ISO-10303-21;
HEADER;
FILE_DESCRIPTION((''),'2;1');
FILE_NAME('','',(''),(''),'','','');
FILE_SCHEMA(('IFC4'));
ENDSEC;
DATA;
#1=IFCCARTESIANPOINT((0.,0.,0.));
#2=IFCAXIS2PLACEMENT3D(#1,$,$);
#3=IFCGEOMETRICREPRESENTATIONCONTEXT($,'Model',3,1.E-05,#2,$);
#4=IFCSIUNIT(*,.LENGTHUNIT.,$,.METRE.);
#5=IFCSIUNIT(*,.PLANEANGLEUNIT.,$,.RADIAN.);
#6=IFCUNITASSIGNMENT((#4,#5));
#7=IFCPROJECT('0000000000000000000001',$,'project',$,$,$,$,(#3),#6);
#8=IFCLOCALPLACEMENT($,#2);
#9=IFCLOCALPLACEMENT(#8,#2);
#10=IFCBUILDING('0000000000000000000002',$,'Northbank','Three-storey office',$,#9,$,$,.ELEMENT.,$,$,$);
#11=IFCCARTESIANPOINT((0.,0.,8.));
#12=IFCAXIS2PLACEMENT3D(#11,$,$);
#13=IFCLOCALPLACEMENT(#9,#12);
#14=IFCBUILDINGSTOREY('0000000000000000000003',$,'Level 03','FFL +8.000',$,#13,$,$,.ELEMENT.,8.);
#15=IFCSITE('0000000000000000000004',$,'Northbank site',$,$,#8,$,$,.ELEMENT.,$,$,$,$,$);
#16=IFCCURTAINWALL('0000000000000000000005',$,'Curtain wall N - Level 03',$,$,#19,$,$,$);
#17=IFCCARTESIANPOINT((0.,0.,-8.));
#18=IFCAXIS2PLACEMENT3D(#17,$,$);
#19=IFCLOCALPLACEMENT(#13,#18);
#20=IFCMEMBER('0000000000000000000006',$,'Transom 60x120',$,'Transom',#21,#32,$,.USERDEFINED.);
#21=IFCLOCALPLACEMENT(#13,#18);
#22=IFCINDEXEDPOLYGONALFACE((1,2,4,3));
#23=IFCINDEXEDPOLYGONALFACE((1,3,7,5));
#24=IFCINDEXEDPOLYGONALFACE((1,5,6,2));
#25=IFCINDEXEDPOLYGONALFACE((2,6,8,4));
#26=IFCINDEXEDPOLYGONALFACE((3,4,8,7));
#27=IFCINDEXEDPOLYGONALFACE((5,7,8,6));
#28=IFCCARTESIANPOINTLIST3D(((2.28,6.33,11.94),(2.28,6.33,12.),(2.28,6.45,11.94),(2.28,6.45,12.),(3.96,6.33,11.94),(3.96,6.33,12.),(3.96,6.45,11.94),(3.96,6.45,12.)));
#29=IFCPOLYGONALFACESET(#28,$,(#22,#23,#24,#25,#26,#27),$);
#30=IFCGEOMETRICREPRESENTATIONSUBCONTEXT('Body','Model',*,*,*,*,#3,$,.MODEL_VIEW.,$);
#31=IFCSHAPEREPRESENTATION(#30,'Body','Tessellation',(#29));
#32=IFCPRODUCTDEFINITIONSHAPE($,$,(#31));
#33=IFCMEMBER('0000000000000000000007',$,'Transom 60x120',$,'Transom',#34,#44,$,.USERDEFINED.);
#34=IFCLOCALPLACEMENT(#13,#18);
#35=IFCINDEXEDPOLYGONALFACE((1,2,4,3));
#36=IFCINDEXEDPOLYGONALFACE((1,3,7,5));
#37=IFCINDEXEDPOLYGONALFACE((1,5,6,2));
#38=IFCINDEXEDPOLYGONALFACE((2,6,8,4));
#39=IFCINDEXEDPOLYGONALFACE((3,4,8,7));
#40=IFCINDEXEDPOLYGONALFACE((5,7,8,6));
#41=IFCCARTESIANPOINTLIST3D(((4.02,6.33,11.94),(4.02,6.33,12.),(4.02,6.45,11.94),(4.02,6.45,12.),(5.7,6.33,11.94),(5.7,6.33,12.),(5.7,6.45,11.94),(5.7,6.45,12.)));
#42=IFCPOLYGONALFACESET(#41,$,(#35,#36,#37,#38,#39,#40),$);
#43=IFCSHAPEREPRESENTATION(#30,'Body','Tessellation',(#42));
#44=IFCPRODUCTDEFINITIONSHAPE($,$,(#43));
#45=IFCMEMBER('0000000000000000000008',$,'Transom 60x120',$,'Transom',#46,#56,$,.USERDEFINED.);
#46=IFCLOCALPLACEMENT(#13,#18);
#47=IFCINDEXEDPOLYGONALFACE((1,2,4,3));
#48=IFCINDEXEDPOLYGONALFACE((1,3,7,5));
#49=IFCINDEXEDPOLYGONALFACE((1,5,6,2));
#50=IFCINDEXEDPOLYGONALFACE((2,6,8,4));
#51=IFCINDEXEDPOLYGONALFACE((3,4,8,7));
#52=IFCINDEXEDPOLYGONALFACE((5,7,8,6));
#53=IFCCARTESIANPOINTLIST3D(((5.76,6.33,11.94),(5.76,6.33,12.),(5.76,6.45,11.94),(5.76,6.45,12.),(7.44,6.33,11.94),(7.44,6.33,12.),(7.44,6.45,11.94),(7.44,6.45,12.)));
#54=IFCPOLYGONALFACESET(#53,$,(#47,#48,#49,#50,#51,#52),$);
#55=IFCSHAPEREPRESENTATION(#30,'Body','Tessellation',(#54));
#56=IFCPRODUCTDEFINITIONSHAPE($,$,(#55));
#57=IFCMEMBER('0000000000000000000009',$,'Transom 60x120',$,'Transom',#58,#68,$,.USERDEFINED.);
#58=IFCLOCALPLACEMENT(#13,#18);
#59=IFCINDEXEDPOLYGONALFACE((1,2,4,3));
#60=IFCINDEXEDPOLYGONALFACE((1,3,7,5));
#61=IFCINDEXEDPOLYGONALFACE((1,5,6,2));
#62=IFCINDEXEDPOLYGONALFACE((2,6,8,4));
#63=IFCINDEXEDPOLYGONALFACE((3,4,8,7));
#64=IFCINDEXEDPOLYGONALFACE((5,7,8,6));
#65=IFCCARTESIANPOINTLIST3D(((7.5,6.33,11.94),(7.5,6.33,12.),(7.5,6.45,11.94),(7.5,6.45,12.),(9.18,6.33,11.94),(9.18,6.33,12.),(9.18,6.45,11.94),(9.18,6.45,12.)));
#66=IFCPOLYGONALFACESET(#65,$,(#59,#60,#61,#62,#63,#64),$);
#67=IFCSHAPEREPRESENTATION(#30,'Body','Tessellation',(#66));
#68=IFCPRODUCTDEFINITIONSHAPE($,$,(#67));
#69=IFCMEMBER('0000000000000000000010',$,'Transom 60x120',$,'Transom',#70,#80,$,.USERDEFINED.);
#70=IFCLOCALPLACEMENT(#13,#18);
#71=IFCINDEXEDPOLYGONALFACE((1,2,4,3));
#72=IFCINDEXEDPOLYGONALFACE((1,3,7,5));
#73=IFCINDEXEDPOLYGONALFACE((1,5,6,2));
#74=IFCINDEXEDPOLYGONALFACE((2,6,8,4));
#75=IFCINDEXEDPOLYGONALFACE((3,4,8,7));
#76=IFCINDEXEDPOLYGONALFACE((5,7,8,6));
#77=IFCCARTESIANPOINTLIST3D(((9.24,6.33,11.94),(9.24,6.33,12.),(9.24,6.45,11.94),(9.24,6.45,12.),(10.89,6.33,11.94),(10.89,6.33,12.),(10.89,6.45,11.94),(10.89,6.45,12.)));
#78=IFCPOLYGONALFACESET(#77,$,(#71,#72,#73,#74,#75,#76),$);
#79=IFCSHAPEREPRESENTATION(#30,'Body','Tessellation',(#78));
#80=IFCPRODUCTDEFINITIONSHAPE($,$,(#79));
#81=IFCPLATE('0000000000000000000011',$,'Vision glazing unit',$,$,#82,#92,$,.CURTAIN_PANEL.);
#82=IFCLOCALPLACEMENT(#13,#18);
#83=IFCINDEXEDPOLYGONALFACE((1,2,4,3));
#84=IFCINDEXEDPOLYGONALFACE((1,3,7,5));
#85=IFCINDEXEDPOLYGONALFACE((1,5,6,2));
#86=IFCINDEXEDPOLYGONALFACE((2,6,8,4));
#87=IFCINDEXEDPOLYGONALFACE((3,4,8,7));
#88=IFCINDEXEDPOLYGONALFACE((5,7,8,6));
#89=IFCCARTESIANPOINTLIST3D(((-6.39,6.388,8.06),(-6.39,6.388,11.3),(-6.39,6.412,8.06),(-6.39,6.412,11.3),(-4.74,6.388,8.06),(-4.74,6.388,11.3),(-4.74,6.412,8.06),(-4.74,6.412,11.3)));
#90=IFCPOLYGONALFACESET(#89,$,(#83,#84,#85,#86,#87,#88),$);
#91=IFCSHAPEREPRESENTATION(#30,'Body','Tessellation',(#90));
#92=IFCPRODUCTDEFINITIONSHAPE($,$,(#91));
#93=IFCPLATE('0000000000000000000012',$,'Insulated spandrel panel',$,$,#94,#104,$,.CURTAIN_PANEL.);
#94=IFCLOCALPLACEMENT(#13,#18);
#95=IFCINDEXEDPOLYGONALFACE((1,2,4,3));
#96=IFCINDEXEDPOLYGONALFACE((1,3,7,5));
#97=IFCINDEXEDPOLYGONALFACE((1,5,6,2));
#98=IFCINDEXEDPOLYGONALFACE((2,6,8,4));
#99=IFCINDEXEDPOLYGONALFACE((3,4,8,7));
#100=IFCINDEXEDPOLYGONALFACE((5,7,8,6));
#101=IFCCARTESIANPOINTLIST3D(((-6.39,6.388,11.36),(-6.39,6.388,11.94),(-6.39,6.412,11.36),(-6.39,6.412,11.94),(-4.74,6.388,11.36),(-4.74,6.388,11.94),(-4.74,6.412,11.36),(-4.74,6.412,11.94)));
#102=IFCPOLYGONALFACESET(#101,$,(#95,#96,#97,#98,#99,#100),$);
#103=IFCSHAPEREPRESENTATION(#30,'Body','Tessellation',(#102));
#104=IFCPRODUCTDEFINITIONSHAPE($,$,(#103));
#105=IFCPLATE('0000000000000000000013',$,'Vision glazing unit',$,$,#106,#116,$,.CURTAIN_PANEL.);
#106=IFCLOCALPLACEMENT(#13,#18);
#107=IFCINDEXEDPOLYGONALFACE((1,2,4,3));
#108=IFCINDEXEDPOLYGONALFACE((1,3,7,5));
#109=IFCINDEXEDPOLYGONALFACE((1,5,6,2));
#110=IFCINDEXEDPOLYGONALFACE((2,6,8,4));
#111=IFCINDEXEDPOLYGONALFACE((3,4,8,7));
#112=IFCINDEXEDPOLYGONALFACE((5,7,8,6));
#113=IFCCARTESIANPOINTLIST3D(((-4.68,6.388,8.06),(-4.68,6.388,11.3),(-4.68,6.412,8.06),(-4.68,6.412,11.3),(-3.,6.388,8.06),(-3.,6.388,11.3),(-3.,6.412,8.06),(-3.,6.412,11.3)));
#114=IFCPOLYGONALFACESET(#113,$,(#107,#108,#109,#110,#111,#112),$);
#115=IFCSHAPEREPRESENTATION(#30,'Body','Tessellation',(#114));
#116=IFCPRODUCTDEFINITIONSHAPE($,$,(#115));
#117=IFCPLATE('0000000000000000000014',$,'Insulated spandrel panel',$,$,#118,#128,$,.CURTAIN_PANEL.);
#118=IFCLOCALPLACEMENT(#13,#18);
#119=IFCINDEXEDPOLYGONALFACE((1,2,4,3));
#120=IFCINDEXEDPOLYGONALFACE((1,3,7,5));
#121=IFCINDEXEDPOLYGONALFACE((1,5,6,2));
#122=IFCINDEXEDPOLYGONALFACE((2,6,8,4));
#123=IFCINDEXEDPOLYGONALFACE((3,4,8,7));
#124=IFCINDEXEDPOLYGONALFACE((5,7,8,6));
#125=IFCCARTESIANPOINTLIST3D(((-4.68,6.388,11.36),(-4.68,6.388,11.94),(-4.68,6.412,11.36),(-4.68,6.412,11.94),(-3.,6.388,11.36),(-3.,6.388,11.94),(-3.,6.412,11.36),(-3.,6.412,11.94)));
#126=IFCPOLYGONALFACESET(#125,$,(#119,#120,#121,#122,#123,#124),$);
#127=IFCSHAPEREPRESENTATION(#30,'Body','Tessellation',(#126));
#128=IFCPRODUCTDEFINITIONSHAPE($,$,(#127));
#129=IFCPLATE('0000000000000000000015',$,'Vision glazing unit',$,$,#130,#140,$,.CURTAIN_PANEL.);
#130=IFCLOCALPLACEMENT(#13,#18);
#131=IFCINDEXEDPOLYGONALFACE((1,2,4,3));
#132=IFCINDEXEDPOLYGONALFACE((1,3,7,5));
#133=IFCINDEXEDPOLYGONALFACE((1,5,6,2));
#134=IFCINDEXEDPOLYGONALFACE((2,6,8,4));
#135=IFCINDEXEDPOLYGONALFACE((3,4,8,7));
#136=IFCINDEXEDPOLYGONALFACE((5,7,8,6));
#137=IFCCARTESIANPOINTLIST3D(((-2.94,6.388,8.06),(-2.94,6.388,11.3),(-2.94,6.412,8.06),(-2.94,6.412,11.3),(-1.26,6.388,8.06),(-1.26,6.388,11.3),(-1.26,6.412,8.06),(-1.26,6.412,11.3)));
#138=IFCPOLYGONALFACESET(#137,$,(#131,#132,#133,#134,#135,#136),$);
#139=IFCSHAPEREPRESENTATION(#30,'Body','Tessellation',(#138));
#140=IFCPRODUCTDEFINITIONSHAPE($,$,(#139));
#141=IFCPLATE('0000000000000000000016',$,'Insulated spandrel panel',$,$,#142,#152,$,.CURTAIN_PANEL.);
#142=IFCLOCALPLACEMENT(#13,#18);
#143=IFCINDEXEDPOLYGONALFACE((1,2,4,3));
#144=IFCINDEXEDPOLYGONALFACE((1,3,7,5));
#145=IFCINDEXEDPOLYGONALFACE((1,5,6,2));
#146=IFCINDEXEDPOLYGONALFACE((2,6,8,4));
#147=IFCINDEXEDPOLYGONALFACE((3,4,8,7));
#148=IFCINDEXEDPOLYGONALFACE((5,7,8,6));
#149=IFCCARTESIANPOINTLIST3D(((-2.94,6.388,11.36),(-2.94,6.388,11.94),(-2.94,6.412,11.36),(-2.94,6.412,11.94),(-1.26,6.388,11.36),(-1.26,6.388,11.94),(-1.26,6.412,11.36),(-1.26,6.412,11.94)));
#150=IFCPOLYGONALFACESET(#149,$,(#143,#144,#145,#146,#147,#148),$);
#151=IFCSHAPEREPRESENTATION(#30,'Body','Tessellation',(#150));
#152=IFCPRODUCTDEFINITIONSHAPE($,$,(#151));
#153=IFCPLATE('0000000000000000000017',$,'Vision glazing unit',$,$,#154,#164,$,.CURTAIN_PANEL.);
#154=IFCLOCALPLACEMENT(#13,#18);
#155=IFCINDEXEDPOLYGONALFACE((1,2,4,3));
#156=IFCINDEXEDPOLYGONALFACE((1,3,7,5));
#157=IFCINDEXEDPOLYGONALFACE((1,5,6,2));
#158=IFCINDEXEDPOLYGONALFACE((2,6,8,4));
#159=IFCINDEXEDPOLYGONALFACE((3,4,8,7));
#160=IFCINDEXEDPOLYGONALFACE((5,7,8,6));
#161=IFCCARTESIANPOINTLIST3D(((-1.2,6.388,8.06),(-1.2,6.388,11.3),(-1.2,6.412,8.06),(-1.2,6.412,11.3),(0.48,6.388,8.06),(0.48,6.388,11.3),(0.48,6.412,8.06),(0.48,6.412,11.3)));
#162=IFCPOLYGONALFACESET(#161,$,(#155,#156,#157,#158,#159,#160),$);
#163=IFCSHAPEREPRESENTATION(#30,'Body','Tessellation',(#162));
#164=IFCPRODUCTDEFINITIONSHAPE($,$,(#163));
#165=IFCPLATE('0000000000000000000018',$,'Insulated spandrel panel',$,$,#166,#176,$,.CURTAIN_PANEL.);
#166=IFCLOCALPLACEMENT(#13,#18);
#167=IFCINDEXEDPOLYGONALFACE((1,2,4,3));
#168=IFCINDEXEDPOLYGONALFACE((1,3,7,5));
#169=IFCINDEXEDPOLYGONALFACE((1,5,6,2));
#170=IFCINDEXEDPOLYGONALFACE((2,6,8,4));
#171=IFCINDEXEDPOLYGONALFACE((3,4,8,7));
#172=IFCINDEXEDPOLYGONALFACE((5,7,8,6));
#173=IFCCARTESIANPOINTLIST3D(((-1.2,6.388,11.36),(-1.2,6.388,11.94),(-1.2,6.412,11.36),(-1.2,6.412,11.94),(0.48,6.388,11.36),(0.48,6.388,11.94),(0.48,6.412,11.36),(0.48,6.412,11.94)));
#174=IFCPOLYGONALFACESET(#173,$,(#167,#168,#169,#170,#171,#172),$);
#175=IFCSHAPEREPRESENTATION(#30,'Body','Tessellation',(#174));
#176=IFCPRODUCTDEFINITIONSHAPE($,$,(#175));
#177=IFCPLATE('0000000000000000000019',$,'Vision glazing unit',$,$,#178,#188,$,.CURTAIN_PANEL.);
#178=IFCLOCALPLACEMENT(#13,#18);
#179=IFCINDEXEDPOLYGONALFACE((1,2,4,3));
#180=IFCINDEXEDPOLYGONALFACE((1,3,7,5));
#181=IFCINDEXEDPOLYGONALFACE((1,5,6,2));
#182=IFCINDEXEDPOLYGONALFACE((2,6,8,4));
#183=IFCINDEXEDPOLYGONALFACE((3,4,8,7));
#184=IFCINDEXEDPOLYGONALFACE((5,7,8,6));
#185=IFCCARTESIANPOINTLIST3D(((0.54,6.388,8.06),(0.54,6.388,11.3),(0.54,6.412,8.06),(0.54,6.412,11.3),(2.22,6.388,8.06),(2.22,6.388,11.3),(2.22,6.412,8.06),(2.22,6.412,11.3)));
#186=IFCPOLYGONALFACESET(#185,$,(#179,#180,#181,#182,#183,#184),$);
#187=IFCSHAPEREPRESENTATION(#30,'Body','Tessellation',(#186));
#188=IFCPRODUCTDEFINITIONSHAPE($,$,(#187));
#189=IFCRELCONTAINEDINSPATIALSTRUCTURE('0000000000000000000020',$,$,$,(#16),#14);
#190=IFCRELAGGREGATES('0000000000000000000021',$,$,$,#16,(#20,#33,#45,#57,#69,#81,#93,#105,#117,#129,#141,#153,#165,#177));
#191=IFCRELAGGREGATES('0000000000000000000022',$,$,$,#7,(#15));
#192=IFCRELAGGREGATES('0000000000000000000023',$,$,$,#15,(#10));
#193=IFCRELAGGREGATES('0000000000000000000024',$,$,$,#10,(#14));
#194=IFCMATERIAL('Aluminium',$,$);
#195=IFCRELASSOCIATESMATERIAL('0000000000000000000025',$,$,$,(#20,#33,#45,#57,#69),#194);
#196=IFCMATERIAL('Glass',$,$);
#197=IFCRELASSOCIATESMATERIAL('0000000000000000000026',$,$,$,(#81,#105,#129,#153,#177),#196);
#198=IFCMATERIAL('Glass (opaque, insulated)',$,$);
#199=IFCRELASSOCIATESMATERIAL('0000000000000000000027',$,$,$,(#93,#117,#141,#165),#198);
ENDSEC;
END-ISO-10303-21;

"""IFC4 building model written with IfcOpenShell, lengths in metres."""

from ifc_helpers import new_model, si_unit, frame, origin, place, context, subcontext, project, spatial, rectangle, extrude, material, element, aggregate, save


model = new_model("IFC4")

# Units and contexts
model_context = context("Model", 3, precision=1e-05, world=origin())
body_context = subcontext(model_context, "Body", "Model", "MODEL_VIEW")
ifc_project = project(units=[si_unit("LENGTHUNIT", "METRE"), si_unit("PLANEANGLEUNIT", "RADIAN")], contexts=[model_context])

# Site, building, storey
site_placement = place(None, origin())
site = spatial("IfcSite", under=ifc_project, at=site_placement, Name="Northbank site", CompositionType="ELEMENT")
building_placement = place(site_placement, origin())
building = spatial("IfcBuilding", under=site, at=building_placement, Name="Northbank", Description="Three-storey office", CompositionType="ELEMENT")
storey_placement = place(building_placement, frame((0.0, 0.0, 8.0)))
storey = spatial("IfcBuildingStorey", under=building, at=storey_placement, Name="Level 03", Description="FFL +8.000", CompositionType="ELEMENT", Elevation=8.0)

# Curtain wall, members, plates
curtain_wall_placement = place(storey_placement, frame((0.0, 0.0, -8.0)))
curtain_wall = element("IfcCurtainWall", 1, at=curtain_wall_placement, inside=storey, Name="Curtain wall N - Level 03")
ifc_material_1 = material(Name="Aluminium")
member_1_placement = place(storey_placement, frame((0.0, 0.0, -8.0)))
member_1 = element("IfcMember", 2, at=member_1_placement, material=ifc_material_1, Name="Transom 60x120", ObjectType="Transom", PredefinedType="USERDEFINED", context=body_context, shape_type="SweptSolid", body=[
    extrude(rectangle(XDim=1.68, YDim=0.12), frame((3.12, 6.39, 11.94)), (0.0, 0.0, 1.0), 0.06),
])
member_2_placement = place(storey_placement, frame((0.0, 0.0, -8.0)))
member_2 = element("IfcMember", 3, at=member_2_placement, material=ifc_material_1, Name="Transom 60x120", ObjectType="Transom", PredefinedType="USERDEFINED", context=body_context, shape_type="SweptSolid", body=[
    extrude(rectangle(XDim=1.68, YDim=0.12), frame((4.86, 6.39, 11.94)), (0.0, 0.0, 1.0), 0.06),
])
member_3_placement = place(storey_placement, frame((0.0, 0.0, -8.0)))
member_3 = element("IfcMember", 4, at=member_3_placement, material=ifc_material_1, Name="Transom 60x120", ObjectType="Transom", PredefinedType="USERDEFINED", context=body_context, shape_type="SweptSolid", body=[
    extrude(rectangle(XDim=1.68, YDim=0.12), frame((6.6, 6.39, 11.94)), (0.0, 0.0, 1.0), 0.06),
])
member_4_placement = place(storey_placement, frame((0.0, 0.0, -8.0)))
member_4 = element("IfcMember", 5, at=member_4_placement, material=ifc_material_1, Name="Transom 60x120", ObjectType="Transom", PredefinedType="USERDEFINED", context=body_context, shape_type="SweptSolid", body=[
    extrude(rectangle(XDim=1.68, YDim=0.12), frame((8.34, 6.39, 11.94)), (0.0, 0.0, 1.0), 0.06),
])
member_5_placement = place(storey_placement, frame((0.0, 0.0, -8.0)))
member_5 = element("IfcMember", 6, at=member_5_placement, material=ifc_material_1, Name="Transom 60x120", ObjectType="Transom", PredefinedType="USERDEFINED", context=body_context, shape_type="SweptSolid", body=[
    extrude(rectangle(XDim=1.65, YDim=0.12), frame((10.065, 6.39, 11.94)), (0.0, 0.0, 1.0), 0.06),
])
ifc_material_2 = material(Name="Glass")
plate_1_placement = place(storey_placement, frame((0.0, 0.0, -8.0)))
plate_1 = element("IfcPlate", 7, at=plate_1_placement, material=ifc_material_2, Name="Vision glazing unit", PredefinedType="CURTAIN_PANEL", context=body_context, shape_type="SweptSolid", body=[
    extrude(rectangle(XDim=1.65, YDim=0.024), frame((-5.565, 6.4, 8.06)), (0.0, 0.0, 1.0), 3.24),
])
ifc_material_3 = material(Name="Glass (opaque, insulated)")
plate_2_placement = place(storey_placement, frame((0.0, 0.0, -8.0)))
plate_2 = element("IfcPlate", 8, at=plate_2_placement, material=ifc_material_3, Name="Insulated spandrel panel", PredefinedType="CURTAIN_PANEL", context=body_context, shape_type="SweptSolid", body=[
    extrude(rectangle(XDim=1.65, YDim=0.024), frame((-5.565, 6.4, 11.36)), (0.0, 0.0, 1.0), 0.58),
])
plate_3_placement = place(storey_placement, frame((0.0, 0.0, -8.0)))
plate_3 = element("IfcPlate", 9, at=plate_3_placement, material=ifc_material_2, Name="Vision glazing unit", PredefinedType="CURTAIN_PANEL", context=body_context, shape_type="SweptSolid", body=[
    extrude(rectangle(XDim=1.68, YDim=0.024), frame((-3.84, 6.4, 8.06)), (0.0, 0.0, 1.0), 3.24),
])
plate_4_placement = place(storey_placement, frame((0.0, 0.0, -8.0)))
plate_4 = element("IfcPlate", 10, at=plate_4_placement, material=ifc_material_3, Name="Insulated spandrel panel", PredefinedType="CURTAIN_PANEL", context=body_context, shape_type="SweptSolid", body=[
    extrude(rectangle(XDim=1.68, YDim=0.024), frame((-3.84, 6.4, 11.36)), (0.0, 0.0, 1.0), 0.58),
])
plate_5_placement = place(storey_placement, frame((0.0, 0.0, -8.0)))
plate_5 = element("IfcPlate", 11, at=plate_5_placement, material=ifc_material_2, Name="Vision glazing unit", PredefinedType="CURTAIN_PANEL", context=body_context, shape_type="SweptSolid", body=[
    extrude(rectangle(XDim=1.68, YDim=0.024), frame((-2.1, 6.4, 8.06)), (0.0, 0.0, 1.0), 3.24),
])
plate_6_placement = place(storey_placement, frame((0.0, 0.0, -8.0)))
plate_6 = element("IfcPlate", 12, at=plate_6_placement, material=ifc_material_3, Name="Insulated spandrel panel", PredefinedType="CURTAIN_PANEL", context=body_context, shape_type="SweptSolid", body=[
    extrude(rectangle(XDim=1.68, YDim=0.024), frame((-2.1, 6.4, 11.36)), (0.0, 0.0, 1.0), 0.58),
])
plate_7_placement = place(storey_placement, frame((0.0, 0.0, -8.0)))
plate_7 = element("IfcPlate", 13, at=plate_7_placement, material=ifc_material_2, Name="Vision glazing unit", PredefinedType="CURTAIN_PANEL", context=body_context, shape_type="SweptSolid", body=[
    extrude(rectangle(XDim=1.68, YDim=0.024), frame((-0.36, 6.4, 8.06)), (0.0, 0.0, 1.0), 3.24),
])
plate_8_placement = place(storey_placement, frame((0.0, 0.0, -8.0)))
plate_8 = element("IfcPlate", 14, at=plate_8_placement, material=ifc_material_3, Name="Insulated spandrel panel", PredefinedType="CURTAIN_PANEL", context=body_context, shape_type="SweptSolid", body=[
    extrude(rectangle(XDim=1.68, YDim=0.024), frame((-0.36, 6.4, 11.36)), (0.0, 0.0, 1.0), 0.58),
])
plate_9_placement = place(storey_placement, frame((0.0, 0.0, -8.0)))
plate_9 = element("IfcPlate", 15, at=plate_9_placement, material=ifc_material_2, Name="Vision glazing unit", PredefinedType="CURTAIN_PANEL", context=body_context, shape_type="SweptSolid", body=[
    extrude(rectangle(XDim=1.68, YDim=0.024), frame((1.38, 6.4, 8.06)), (0.0, 0.0, 1.0), 3.24),
])
aggregate(curtain_wall, [member_1, member_2, member_3, member_4, member_5, plate_1, plate_2, plate_3, plate_4, plate_5, plate_6, plate_7, plate_8, plate_9])

save(model, "model.ifc")
